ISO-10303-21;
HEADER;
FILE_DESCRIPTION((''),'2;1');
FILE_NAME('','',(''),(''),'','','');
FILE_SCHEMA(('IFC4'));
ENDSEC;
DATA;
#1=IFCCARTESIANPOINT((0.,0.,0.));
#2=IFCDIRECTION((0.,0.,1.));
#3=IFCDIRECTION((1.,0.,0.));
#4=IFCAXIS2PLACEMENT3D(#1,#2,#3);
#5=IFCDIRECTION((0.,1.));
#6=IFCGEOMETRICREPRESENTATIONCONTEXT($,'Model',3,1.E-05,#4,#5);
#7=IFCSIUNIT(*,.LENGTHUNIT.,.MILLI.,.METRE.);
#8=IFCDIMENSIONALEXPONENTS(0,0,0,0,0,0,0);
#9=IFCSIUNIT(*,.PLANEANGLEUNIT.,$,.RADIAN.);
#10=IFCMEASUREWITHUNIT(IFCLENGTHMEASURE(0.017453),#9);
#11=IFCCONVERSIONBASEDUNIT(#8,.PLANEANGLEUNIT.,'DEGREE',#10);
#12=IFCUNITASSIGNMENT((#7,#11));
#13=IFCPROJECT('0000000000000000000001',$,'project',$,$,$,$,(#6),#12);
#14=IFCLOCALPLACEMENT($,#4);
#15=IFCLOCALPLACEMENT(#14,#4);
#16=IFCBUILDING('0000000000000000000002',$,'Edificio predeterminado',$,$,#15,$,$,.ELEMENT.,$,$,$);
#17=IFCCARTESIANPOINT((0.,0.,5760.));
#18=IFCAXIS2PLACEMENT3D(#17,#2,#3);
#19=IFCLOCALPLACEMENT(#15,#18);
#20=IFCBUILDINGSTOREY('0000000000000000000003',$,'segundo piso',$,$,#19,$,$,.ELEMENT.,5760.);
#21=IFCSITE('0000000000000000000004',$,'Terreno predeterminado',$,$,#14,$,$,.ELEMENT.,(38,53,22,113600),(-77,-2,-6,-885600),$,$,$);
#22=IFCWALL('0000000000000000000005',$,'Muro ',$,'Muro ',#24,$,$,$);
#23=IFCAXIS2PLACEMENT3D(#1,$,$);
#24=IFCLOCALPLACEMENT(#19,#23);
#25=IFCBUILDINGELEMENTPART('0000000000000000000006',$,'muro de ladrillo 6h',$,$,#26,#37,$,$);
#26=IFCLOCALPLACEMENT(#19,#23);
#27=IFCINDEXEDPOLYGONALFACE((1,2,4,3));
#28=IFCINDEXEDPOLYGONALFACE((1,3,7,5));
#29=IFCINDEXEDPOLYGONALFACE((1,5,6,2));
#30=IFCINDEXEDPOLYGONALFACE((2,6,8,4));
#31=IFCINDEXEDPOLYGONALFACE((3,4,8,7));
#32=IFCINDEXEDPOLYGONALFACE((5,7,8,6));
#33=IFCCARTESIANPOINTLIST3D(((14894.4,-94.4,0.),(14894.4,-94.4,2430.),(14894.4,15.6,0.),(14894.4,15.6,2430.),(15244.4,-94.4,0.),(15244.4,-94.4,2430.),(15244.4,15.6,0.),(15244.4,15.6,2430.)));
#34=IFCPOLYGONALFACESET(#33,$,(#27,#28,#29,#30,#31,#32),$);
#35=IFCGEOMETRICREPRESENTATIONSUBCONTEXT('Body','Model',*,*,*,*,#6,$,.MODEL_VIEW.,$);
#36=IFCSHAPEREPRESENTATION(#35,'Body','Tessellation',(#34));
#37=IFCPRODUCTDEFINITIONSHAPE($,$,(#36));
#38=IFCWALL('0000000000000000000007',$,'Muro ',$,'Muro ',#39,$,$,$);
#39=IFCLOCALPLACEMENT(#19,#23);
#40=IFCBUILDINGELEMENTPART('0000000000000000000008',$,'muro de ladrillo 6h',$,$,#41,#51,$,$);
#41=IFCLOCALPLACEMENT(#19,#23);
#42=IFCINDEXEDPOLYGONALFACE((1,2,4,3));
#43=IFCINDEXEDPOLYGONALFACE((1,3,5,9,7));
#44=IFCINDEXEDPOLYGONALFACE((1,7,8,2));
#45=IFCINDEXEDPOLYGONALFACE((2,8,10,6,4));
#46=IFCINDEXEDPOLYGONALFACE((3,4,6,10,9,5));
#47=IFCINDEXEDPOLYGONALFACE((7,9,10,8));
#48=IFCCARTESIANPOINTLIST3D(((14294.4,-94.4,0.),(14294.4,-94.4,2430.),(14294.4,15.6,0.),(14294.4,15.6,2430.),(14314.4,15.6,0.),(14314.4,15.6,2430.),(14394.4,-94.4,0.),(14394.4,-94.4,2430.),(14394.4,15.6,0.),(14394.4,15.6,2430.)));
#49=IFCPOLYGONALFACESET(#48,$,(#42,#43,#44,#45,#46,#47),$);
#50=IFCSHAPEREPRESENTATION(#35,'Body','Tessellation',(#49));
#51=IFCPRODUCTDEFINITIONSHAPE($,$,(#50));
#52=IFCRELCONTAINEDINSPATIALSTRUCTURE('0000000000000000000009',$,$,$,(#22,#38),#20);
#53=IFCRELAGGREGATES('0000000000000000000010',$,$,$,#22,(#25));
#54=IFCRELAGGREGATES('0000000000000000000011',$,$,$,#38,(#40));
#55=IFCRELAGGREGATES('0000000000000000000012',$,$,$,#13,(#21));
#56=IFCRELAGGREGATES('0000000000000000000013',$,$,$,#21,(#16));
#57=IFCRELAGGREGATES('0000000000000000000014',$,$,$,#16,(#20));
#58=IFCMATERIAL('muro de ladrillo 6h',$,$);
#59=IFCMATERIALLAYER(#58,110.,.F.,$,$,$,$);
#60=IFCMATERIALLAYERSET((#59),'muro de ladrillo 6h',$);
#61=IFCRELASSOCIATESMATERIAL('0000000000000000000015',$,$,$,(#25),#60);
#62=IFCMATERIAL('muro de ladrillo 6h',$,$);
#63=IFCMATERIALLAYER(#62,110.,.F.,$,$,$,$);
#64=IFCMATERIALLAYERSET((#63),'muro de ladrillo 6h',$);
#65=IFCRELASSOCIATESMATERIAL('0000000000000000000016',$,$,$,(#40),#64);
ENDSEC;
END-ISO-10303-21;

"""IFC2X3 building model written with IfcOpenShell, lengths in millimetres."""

from ifc_helpers import new_model, entity, si_unit, converted_unit, direction, frame, origin_with_axes, place, context, subcontext, project, spatial, polyline, outline, extrude, material, layer, layer_set, layer_usage, element, aggregate, save


model = new_model("IFC2X3")

# Units and contexts
model_context = context("Model", 3, precision=1e-05, world=origin_with_axes(), true_north=direction((0.0, 1.0)))
body_context = subcontext(model_context, "Body", "Model", "MODEL_VIEW")
ifc_project = project(units=[si_unit("LENGTHUNIT", "METRE", prefix="MILLI"), converted_unit("PLANEANGLEUNIT", "DEGREE", entity("IfcLengthMeasure", 0.017453), si_unit("PLANEANGLEUNIT", "RADIAN"), dimensions=[0, 0, 0, 0, 0, 0, 0])], contexts=[model_context])

# Site, building, storey
site_placement = place(None, origin_with_axes())
site = spatial("IfcSite", under=ifc_project, at=site_placement, Name="Terreno predeterminado", CompositionType="ELEMENT", RefLatitude=(38, 53, 22, 113600), RefLongitude=(-77, -2, -6, -885600))
building_placement = place(site_placement, origin_with_axes())
building = spatial("IfcBuilding", under=site, at=building_placement, Name="Edificio predeterminado", CompositionType="ELEMENT")
storey_placement = place(building_placement, frame((0.0, 0.0, 5760.0), z_axis=(0.0, 0.0, 1.0), x_axis=(1.0, 0.0, 0.0)))
storey = spatial("IfcBuildingStorey", under=building, at=storey_placement, Name="segundo piso", CompositionType="ELEMENT", Elevation=5760.0)

# Walls, building element parts
wall_1_placement = place(storey_placement, frame((15244.4, -39.4, 0.0), z_axis=(0.0, 0.0, 1.0), x_axis=(-1.0, 0.0, 0.0)))
wall_1 = element("IfcWall", 1, at=wall_1_placement, inside=storey, Name="Muro ", ObjectType="Muro ")
ifc_material_1 = material(Name="muro de ladrillo 6h")
ifc_layer_1 = layer(ifc_material_1, 110.0, ventilated=False)
ifc_layer_set_1 = layer_set([ifc_layer_1], Name="muro de ladrillo 6h")
ifc_layer_usage_1 = layer_usage(ifc_layer_set_1, "AXIS2", "NEGATIVE", -55.0)
building_element_part_1_placement = place(wall_1_placement, origin_with_axes())
building_element_part_1 = element("IfcBuildingElementPart", 2, at=building_element_part_1_placement, material=ifc_layer_usage_1, Name="muro de ladrillo 6h", context=body_context, shape_type="SweptSolid", body=[
    extrude(outline(polyline([(350.0, 55.0), (350.0, -55.0), (0.0, -55.0), (0.0, 55.0), (350.0, 55.0)])), origin_with_axes(), (0.0, 0.0, 1.0), 2430.0),
])
aggregate(wall_1, [building_element_part_1])
wall_2_placement = place(storey_placement, frame((14394.4, -39.4, 0.0), z_axis=(0.0, 0.0, 1.0), x_axis=(-1.0, 0.0, 0.0)))
wall_2 = element("IfcWall", 3, at=wall_2_placement, inside=storey, Name="Muro ", ObjectType="Muro ")
ifc_material_2 = material(Name="muro de ladrillo 6h")
ifc_layer_2 = layer(ifc_material_2, 110.0, ventilated=False)
ifc_layer_set_2 = layer_set([ifc_layer_2], Name="muro de ladrillo 6h")
ifc_layer_usage_2 = layer_usage(ifc_layer_set_2, "AXIS2", "NEGATIVE", -55.0)
building_element_part_2_placement = place(wall_2_placement, origin_with_axes())
building_element_part_2 = element("IfcBuildingElementPart", 4, at=building_element_part_2_placement, material=ifc_layer_usage_2, Name="muro de ladrillo 6h", context=body_context, shape_type="SweptSolid", body=[
    extrude(outline(polyline([(100.0, 55.0), (100.0, -55.0), (80.0, -55.0), (0.0, -55.0), (0.0, 55.0), (100.0, 55.0)])), origin_with_axes(), (0.0, 0.0, 1.0), 2430.0),
])
aggregate(wall_2, [building_element_part_2])

save(model, "model.ifc")
